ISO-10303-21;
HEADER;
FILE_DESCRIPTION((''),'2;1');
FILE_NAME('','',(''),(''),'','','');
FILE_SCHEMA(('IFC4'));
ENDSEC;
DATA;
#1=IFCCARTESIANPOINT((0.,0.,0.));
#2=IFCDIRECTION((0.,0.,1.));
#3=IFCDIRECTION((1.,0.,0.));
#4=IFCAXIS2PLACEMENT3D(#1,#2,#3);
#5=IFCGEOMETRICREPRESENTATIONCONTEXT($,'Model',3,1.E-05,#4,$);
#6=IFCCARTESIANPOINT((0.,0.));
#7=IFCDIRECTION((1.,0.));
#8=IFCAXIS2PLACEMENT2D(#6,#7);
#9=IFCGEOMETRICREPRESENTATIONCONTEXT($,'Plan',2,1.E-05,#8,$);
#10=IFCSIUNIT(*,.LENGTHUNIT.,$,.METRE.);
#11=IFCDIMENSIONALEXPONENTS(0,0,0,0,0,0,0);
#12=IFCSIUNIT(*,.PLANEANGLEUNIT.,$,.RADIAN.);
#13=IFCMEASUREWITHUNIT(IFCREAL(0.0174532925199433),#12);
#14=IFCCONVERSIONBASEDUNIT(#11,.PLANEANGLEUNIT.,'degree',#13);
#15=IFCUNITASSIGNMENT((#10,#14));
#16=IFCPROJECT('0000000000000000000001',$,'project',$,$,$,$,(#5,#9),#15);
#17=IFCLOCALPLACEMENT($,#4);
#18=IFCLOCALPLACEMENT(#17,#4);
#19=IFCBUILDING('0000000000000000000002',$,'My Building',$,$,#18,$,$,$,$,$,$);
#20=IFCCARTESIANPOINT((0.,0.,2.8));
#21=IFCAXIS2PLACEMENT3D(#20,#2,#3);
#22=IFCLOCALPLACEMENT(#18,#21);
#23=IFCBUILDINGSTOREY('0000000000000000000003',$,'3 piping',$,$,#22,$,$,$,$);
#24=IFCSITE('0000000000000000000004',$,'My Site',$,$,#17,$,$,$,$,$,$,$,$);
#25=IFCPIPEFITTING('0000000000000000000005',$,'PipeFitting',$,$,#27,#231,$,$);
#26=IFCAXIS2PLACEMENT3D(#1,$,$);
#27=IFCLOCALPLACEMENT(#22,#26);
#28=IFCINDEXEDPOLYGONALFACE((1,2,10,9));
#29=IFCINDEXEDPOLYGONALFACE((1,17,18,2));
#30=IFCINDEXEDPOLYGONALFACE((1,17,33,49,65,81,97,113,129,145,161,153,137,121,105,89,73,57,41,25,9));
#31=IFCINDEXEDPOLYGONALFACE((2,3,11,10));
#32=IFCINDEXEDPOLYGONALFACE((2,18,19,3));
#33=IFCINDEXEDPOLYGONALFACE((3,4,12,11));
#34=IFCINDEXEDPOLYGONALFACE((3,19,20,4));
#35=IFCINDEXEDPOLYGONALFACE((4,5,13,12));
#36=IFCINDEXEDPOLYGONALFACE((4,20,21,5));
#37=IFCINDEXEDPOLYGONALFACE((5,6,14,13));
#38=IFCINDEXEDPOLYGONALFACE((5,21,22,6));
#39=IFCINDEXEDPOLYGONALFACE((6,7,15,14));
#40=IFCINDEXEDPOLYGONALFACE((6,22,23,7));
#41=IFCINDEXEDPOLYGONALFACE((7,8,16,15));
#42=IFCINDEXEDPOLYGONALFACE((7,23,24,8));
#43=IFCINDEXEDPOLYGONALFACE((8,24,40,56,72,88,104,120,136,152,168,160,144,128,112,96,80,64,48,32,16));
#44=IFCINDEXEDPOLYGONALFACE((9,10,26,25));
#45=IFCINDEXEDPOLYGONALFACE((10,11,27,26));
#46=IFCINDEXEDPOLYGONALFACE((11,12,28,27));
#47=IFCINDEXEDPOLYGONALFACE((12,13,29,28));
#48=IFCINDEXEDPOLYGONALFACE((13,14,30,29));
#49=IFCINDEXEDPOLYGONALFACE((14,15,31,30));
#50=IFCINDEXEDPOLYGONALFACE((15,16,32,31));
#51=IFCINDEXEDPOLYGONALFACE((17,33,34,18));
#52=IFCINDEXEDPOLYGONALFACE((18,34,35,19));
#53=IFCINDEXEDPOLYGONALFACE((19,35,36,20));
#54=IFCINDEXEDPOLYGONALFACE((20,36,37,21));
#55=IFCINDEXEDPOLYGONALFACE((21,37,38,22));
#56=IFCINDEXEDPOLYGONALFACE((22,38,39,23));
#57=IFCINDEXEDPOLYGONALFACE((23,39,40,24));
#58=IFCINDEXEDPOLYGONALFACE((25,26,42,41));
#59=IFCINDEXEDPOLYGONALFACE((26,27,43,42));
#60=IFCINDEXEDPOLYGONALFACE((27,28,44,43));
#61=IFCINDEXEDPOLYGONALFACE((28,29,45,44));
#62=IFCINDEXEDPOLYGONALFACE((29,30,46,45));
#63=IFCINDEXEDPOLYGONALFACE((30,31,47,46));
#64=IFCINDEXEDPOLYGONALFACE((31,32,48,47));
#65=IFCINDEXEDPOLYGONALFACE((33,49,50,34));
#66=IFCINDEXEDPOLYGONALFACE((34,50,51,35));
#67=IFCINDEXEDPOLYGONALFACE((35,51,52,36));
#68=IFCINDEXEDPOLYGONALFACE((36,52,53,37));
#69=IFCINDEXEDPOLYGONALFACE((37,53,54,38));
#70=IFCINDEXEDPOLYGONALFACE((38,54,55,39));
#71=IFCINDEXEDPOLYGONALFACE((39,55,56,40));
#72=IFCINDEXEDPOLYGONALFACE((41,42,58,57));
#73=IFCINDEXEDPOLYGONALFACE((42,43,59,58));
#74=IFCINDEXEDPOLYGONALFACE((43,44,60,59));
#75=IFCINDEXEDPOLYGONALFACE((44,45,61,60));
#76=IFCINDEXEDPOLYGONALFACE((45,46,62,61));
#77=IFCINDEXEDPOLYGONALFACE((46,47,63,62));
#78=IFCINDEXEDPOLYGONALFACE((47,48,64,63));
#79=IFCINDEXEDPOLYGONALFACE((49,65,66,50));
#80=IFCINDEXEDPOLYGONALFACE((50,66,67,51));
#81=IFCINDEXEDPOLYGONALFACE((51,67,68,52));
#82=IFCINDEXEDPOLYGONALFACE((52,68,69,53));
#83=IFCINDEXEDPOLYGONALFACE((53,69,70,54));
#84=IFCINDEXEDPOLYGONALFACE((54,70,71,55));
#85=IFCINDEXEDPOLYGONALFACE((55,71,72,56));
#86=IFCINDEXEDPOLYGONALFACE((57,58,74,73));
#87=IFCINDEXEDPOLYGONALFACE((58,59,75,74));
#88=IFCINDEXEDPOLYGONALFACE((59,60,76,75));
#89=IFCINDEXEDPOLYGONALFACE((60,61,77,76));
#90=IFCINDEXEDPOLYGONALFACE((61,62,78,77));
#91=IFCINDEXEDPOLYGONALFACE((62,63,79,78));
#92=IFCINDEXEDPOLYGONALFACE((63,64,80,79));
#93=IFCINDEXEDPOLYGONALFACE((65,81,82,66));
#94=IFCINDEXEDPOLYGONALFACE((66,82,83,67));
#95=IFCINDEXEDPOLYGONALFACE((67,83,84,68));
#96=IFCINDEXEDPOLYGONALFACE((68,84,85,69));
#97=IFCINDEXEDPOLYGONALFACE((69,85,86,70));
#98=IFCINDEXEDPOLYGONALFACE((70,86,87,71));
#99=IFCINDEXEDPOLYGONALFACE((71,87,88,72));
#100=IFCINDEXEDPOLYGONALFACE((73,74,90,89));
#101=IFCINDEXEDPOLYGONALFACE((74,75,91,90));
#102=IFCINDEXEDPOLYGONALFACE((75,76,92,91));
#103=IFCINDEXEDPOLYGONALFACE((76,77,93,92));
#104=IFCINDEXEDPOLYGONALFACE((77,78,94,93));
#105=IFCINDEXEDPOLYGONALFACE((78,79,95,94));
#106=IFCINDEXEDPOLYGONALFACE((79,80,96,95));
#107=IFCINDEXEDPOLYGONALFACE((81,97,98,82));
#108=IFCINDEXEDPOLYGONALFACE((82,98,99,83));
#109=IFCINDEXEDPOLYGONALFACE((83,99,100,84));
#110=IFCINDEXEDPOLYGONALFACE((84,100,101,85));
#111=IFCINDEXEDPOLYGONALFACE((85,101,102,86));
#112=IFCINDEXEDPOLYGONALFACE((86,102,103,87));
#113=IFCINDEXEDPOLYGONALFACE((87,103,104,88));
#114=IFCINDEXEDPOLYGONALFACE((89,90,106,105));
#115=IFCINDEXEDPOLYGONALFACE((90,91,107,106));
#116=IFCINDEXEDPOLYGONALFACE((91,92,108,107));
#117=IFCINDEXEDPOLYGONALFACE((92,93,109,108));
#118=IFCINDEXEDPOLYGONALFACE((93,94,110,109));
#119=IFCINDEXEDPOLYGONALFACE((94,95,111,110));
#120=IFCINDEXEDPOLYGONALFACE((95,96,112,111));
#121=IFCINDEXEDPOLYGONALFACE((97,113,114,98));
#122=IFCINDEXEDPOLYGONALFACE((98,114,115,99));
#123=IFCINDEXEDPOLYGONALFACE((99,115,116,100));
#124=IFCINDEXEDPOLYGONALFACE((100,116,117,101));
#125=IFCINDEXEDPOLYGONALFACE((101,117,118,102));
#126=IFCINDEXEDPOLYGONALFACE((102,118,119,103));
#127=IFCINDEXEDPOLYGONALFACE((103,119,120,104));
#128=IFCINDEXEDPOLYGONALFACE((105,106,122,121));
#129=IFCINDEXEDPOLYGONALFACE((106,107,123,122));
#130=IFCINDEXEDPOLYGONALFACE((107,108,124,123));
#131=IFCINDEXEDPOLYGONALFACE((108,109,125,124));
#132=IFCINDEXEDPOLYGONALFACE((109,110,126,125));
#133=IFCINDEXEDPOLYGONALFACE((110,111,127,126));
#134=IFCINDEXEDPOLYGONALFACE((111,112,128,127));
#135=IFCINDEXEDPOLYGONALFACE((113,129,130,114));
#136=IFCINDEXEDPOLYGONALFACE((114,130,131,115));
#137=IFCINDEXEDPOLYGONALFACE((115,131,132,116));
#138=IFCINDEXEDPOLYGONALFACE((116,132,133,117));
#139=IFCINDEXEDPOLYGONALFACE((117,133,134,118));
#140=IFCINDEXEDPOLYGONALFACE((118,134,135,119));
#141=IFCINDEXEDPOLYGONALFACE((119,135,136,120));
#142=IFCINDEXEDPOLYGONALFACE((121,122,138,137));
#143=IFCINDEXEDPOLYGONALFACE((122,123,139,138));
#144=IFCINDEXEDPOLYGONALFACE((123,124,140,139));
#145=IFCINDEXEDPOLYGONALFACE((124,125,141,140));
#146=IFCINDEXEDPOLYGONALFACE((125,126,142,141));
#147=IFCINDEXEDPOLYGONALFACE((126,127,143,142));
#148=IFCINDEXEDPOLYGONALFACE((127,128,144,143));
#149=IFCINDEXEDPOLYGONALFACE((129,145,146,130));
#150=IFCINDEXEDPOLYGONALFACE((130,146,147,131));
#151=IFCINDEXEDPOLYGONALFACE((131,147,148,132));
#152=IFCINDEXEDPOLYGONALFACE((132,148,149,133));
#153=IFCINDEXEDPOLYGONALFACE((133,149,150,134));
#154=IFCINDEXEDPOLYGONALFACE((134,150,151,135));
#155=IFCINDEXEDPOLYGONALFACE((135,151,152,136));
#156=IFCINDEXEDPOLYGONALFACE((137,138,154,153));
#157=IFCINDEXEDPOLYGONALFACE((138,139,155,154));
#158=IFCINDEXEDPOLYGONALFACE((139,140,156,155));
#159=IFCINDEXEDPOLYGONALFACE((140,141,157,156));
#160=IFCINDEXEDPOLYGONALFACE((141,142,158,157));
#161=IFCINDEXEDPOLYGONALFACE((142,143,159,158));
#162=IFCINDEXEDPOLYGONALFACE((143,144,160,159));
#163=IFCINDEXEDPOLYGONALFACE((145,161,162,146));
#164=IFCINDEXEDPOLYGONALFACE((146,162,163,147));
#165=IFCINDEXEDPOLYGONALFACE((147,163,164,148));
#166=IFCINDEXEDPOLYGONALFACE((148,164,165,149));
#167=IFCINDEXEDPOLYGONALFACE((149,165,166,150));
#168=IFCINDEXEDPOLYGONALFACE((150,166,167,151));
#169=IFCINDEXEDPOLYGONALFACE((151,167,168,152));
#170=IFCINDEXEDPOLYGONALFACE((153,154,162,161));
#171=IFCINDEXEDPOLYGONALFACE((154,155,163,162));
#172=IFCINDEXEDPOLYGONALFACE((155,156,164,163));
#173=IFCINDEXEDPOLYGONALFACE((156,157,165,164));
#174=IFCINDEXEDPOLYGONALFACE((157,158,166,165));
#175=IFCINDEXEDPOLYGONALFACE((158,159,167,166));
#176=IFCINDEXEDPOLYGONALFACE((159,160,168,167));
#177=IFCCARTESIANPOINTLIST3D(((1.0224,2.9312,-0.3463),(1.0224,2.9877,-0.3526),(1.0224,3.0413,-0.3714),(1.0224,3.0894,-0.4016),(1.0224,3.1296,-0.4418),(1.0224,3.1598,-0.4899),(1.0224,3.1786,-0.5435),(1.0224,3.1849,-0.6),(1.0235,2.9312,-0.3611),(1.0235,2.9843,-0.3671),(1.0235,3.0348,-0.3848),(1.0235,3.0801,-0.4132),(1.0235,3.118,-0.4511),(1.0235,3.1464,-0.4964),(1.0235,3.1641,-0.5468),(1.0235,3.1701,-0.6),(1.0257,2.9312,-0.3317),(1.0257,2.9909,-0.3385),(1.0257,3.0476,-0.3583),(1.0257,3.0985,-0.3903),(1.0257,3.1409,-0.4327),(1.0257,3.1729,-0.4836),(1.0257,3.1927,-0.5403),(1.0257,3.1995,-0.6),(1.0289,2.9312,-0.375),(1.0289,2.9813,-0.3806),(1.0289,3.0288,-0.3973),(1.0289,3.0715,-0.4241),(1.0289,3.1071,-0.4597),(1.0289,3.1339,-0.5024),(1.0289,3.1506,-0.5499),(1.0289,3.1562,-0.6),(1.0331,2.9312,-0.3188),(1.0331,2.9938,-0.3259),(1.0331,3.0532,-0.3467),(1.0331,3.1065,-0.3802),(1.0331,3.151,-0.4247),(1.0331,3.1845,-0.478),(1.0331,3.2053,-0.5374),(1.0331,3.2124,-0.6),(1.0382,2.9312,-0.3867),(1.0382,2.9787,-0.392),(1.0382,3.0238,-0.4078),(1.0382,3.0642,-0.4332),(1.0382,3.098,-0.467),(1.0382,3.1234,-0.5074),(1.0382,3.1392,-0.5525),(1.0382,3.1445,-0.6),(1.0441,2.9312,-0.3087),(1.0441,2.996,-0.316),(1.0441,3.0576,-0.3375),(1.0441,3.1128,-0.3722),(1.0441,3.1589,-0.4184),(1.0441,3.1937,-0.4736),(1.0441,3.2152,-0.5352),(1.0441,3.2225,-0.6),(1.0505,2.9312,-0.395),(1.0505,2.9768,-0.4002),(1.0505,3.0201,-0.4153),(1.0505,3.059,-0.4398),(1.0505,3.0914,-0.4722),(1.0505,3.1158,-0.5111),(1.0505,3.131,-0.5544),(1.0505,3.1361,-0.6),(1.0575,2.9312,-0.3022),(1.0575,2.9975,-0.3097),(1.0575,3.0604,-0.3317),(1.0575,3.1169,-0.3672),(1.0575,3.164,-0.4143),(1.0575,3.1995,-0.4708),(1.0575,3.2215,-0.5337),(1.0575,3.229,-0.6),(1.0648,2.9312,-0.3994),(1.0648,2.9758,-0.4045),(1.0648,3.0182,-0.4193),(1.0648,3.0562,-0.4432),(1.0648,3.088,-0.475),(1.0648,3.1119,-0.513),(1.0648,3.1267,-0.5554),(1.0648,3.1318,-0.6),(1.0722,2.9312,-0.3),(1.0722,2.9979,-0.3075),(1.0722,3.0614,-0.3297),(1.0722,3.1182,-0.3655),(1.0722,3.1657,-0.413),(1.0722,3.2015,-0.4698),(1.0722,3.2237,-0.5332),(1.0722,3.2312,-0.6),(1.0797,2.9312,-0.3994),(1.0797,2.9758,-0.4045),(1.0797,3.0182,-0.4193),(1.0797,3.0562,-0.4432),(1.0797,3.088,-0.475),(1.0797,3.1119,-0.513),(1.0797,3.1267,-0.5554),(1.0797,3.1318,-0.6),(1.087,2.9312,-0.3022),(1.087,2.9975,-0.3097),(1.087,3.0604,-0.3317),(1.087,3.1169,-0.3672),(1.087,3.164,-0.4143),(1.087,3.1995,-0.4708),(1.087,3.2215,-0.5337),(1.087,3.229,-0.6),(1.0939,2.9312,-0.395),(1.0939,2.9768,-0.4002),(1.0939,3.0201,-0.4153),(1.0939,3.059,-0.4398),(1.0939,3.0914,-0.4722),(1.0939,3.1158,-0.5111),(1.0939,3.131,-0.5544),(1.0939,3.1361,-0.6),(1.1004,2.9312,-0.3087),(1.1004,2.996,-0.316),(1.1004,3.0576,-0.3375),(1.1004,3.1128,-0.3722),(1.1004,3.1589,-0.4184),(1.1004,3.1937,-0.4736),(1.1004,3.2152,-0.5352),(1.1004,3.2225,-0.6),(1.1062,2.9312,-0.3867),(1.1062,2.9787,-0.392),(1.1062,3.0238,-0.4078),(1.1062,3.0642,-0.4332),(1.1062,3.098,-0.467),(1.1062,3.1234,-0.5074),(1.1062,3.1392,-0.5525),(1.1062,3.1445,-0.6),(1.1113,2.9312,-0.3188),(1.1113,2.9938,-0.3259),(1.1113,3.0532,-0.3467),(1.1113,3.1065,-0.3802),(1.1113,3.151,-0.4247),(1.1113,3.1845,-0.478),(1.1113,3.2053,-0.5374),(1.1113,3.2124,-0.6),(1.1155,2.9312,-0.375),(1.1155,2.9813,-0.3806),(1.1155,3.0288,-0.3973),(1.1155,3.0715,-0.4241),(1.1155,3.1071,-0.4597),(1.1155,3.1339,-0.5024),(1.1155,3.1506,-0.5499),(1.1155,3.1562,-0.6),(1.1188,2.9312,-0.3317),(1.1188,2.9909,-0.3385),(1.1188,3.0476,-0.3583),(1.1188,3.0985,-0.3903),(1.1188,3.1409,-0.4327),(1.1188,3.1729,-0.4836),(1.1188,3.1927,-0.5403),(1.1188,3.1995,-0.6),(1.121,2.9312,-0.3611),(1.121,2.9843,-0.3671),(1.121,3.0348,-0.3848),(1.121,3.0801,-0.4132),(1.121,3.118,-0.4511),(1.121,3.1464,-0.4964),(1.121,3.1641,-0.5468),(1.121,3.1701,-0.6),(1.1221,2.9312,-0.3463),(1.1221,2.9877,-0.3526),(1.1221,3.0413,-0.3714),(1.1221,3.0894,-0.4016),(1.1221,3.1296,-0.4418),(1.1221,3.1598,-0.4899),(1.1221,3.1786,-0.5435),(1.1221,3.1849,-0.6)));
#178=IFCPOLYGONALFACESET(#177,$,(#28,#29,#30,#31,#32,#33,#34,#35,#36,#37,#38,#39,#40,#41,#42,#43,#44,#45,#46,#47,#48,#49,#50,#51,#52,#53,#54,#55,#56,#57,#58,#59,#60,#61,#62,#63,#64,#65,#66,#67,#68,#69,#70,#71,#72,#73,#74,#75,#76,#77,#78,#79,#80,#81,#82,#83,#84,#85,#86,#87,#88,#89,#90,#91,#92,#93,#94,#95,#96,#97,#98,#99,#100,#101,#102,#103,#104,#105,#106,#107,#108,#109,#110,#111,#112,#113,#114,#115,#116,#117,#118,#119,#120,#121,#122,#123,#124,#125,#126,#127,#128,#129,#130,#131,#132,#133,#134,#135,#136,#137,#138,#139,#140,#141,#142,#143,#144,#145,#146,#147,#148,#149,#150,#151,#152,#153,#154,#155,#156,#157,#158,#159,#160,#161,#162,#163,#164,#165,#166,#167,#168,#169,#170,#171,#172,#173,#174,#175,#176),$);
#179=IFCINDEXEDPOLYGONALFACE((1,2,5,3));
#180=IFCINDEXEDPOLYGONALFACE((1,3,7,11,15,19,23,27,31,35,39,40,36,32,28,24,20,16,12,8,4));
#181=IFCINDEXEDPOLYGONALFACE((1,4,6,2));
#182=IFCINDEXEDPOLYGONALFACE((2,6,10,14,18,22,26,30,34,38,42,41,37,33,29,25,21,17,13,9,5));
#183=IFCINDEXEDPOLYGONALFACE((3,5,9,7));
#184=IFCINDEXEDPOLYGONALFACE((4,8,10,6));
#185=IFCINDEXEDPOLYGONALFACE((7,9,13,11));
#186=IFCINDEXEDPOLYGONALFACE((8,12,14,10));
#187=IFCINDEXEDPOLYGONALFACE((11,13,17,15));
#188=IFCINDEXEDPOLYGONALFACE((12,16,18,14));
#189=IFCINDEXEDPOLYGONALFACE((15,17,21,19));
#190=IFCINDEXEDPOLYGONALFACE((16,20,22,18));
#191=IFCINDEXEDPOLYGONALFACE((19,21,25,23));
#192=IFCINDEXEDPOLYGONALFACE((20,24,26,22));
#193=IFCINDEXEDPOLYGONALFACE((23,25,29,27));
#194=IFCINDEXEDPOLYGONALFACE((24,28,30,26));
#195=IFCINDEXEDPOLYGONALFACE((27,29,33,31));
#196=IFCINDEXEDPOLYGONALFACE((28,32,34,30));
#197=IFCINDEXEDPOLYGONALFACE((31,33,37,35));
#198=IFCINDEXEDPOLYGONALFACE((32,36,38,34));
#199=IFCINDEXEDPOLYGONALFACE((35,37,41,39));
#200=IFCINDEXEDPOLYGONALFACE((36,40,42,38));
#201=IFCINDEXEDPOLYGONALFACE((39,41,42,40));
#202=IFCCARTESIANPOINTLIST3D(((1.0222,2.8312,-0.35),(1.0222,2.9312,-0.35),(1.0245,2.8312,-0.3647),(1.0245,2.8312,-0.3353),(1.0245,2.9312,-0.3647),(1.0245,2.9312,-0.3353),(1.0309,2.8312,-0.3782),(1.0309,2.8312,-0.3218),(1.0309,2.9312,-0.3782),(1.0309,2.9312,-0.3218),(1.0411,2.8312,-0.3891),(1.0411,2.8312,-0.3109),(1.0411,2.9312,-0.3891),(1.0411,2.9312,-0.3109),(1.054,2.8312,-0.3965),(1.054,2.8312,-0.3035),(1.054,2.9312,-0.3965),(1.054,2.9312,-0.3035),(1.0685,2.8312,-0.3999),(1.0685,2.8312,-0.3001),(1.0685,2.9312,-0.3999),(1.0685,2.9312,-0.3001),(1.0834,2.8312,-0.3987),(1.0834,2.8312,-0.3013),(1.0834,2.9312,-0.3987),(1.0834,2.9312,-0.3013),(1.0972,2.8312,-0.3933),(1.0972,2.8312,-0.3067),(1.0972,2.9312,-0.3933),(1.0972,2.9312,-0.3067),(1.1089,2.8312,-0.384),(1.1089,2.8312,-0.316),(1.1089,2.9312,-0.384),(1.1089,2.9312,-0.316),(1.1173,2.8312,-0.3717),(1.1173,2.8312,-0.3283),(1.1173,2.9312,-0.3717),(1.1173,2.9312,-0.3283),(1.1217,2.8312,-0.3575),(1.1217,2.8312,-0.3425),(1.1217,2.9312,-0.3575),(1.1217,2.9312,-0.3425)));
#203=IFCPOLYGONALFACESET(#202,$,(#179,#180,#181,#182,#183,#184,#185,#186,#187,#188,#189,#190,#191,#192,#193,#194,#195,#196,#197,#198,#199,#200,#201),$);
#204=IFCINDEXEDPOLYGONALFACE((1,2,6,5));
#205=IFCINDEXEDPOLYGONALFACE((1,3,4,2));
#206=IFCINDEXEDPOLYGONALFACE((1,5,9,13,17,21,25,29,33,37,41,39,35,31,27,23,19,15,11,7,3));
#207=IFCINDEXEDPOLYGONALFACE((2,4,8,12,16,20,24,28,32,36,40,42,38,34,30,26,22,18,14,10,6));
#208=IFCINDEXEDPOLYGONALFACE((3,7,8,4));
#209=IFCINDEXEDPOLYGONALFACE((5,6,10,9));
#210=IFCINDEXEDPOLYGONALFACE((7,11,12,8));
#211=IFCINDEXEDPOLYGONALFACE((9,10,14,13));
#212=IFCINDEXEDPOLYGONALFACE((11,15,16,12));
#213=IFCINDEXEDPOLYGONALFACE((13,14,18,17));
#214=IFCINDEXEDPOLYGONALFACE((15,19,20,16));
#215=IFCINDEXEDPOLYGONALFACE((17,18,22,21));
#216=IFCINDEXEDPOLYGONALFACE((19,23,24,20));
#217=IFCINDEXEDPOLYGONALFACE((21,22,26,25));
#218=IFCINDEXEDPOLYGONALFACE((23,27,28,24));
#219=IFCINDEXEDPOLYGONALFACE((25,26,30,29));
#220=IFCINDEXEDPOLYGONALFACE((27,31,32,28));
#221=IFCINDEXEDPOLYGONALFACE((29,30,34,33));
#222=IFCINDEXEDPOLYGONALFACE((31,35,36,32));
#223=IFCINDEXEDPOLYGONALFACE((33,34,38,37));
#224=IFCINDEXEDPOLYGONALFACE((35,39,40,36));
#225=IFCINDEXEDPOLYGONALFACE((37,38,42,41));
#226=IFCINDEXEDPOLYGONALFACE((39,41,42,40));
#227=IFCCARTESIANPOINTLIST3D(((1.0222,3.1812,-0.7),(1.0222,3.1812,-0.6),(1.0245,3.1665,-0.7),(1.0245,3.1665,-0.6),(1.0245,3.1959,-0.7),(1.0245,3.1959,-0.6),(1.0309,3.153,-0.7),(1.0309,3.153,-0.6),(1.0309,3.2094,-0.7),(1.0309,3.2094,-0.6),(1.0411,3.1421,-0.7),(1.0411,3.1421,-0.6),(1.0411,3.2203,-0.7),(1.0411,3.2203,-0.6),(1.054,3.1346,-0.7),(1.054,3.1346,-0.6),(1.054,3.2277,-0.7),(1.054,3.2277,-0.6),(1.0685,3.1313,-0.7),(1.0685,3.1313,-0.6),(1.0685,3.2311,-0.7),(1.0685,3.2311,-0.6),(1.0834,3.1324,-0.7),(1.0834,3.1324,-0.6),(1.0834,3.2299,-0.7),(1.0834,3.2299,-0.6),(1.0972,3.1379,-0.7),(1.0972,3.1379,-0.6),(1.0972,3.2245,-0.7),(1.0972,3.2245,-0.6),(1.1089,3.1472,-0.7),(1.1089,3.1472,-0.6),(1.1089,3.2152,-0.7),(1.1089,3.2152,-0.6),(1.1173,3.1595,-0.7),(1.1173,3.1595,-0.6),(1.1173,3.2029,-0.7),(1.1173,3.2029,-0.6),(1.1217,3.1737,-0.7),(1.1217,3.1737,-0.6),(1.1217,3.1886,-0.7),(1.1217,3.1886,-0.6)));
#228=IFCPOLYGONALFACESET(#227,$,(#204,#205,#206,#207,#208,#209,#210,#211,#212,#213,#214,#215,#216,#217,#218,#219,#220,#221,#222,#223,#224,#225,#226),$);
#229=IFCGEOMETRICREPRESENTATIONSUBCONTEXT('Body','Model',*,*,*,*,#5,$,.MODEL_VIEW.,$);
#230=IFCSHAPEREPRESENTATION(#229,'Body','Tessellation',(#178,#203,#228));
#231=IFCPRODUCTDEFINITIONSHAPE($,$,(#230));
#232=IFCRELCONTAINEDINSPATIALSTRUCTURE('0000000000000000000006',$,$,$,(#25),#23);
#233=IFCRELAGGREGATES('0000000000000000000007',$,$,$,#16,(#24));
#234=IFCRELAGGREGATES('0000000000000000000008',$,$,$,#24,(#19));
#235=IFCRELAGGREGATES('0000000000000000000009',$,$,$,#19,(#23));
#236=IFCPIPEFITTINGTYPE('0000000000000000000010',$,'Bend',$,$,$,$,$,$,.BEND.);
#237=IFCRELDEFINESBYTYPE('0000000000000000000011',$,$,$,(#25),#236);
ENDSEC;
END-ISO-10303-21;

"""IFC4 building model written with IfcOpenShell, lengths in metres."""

from ifc_helpers import new_model, entity, si_unit, converted_unit, frame, origin_with_axes, origin_2d_with_axis, place, context, subcontext, project, spatial, circle, extrude, source, transform, mapped, type_object, type_shapes, element, save


model = new_model("IFC4")

# Units and contexts
model_context = context("Model", 3, precision=1e-05, world=origin_with_axes())
plan_context = context("Plan", 2, precision=1e-05, world=origin_2d_with_axis())
body_context = subcontext(model_context, "Body", "Model", "MODEL_VIEW")
ifc_project = project(units=[si_unit("LENGTHUNIT", "METRE"), converted_unit("PLANEANGLEUNIT", "degree", entity("IfcReal", 0.0174532925199433), si_unit("PLANEANGLEUNIT", "RADIAN"), dimensions=[0, 0, 0, 0, 0, 0, 0])], contexts=[model_context, plan_context])

# Site, building, storey
site_placement = place(None, origin_with_axes())
site = spatial("IfcSite", under=ifc_project, at=site_placement, Name="My Site")
building_placement = place(site_placement, origin_with_axes())
building = spatial("IfcBuilding", under=site, at=building_placement, Name="My Building")
storey_placement = place(building_placement, frame((0.0, 0.0, 2.8), z_axis=(0.0, 0.0, 1.0), x_axis=(1.0, 0.0, 0.0)))
storey = spatial("IfcBuildingStorey", under=building, at=storey_placement, Name="3 piping")

# Pipe fitting
pipe_fitting_type_1 = type_object("IfcPipeFittingType", Name="Bend", PredefinedType="BEND")
shared_shape = source(origin_with_axes(), body_context, "Body", "SolidModel", [
    entity("IfcSweptDiskSolid", entity("IfcIndexedPolyCurve", entity("IfcCartesianPointList3D", [[0.0, 0.0, 0.1], [0.0, -0.0732, 0.2768], [0.0, -0.25, 0.35]]), [entity("IfcArcIndex", [1, 2, 3])]), 0.05),
    extrude(circle(Radius=0.05), origin_with_axes(), (0.0, 0.0, 1.0), 0.1),
    extrude(circle(Radius=0.05), frame((0.0, -0.25, 0.35), z_axis=(0.0, -1.0, 0.0), x_axis=(1.0, 0.0, 0.0)), (0.0, 0.0, 1.0), 0.1),
])
type_shapes(pipe_fitting_type_1, [shared_shape])
for number, where, z_axis, x_axis, name in (
    (1, (1.0722, 2.8312, -0.35), (0.0, 1.0, 0.0), (-1.0, 0.0, 0.0), "PipeFitting"),
):
    element("IfcPipeFitting", number, at=place(storey_placement, frame(where, z_axis=z_axis, x_axis=x_axis)), inside=storey, type_object=pipe_fitting_type_1, Name=name, context=body_context, shape_type="MappedRepresentation", body=[
        mapped(shared_shape, transform((0.0, 0.0, 0.0), x_axis=(1.0, 0.0, 0.0), y_axis=(0.0, 1.0, 0.0), z_axis=(0.0, 0.0, 1.0), scale=1.0)),
    ])

save(model, "model.ifc")
